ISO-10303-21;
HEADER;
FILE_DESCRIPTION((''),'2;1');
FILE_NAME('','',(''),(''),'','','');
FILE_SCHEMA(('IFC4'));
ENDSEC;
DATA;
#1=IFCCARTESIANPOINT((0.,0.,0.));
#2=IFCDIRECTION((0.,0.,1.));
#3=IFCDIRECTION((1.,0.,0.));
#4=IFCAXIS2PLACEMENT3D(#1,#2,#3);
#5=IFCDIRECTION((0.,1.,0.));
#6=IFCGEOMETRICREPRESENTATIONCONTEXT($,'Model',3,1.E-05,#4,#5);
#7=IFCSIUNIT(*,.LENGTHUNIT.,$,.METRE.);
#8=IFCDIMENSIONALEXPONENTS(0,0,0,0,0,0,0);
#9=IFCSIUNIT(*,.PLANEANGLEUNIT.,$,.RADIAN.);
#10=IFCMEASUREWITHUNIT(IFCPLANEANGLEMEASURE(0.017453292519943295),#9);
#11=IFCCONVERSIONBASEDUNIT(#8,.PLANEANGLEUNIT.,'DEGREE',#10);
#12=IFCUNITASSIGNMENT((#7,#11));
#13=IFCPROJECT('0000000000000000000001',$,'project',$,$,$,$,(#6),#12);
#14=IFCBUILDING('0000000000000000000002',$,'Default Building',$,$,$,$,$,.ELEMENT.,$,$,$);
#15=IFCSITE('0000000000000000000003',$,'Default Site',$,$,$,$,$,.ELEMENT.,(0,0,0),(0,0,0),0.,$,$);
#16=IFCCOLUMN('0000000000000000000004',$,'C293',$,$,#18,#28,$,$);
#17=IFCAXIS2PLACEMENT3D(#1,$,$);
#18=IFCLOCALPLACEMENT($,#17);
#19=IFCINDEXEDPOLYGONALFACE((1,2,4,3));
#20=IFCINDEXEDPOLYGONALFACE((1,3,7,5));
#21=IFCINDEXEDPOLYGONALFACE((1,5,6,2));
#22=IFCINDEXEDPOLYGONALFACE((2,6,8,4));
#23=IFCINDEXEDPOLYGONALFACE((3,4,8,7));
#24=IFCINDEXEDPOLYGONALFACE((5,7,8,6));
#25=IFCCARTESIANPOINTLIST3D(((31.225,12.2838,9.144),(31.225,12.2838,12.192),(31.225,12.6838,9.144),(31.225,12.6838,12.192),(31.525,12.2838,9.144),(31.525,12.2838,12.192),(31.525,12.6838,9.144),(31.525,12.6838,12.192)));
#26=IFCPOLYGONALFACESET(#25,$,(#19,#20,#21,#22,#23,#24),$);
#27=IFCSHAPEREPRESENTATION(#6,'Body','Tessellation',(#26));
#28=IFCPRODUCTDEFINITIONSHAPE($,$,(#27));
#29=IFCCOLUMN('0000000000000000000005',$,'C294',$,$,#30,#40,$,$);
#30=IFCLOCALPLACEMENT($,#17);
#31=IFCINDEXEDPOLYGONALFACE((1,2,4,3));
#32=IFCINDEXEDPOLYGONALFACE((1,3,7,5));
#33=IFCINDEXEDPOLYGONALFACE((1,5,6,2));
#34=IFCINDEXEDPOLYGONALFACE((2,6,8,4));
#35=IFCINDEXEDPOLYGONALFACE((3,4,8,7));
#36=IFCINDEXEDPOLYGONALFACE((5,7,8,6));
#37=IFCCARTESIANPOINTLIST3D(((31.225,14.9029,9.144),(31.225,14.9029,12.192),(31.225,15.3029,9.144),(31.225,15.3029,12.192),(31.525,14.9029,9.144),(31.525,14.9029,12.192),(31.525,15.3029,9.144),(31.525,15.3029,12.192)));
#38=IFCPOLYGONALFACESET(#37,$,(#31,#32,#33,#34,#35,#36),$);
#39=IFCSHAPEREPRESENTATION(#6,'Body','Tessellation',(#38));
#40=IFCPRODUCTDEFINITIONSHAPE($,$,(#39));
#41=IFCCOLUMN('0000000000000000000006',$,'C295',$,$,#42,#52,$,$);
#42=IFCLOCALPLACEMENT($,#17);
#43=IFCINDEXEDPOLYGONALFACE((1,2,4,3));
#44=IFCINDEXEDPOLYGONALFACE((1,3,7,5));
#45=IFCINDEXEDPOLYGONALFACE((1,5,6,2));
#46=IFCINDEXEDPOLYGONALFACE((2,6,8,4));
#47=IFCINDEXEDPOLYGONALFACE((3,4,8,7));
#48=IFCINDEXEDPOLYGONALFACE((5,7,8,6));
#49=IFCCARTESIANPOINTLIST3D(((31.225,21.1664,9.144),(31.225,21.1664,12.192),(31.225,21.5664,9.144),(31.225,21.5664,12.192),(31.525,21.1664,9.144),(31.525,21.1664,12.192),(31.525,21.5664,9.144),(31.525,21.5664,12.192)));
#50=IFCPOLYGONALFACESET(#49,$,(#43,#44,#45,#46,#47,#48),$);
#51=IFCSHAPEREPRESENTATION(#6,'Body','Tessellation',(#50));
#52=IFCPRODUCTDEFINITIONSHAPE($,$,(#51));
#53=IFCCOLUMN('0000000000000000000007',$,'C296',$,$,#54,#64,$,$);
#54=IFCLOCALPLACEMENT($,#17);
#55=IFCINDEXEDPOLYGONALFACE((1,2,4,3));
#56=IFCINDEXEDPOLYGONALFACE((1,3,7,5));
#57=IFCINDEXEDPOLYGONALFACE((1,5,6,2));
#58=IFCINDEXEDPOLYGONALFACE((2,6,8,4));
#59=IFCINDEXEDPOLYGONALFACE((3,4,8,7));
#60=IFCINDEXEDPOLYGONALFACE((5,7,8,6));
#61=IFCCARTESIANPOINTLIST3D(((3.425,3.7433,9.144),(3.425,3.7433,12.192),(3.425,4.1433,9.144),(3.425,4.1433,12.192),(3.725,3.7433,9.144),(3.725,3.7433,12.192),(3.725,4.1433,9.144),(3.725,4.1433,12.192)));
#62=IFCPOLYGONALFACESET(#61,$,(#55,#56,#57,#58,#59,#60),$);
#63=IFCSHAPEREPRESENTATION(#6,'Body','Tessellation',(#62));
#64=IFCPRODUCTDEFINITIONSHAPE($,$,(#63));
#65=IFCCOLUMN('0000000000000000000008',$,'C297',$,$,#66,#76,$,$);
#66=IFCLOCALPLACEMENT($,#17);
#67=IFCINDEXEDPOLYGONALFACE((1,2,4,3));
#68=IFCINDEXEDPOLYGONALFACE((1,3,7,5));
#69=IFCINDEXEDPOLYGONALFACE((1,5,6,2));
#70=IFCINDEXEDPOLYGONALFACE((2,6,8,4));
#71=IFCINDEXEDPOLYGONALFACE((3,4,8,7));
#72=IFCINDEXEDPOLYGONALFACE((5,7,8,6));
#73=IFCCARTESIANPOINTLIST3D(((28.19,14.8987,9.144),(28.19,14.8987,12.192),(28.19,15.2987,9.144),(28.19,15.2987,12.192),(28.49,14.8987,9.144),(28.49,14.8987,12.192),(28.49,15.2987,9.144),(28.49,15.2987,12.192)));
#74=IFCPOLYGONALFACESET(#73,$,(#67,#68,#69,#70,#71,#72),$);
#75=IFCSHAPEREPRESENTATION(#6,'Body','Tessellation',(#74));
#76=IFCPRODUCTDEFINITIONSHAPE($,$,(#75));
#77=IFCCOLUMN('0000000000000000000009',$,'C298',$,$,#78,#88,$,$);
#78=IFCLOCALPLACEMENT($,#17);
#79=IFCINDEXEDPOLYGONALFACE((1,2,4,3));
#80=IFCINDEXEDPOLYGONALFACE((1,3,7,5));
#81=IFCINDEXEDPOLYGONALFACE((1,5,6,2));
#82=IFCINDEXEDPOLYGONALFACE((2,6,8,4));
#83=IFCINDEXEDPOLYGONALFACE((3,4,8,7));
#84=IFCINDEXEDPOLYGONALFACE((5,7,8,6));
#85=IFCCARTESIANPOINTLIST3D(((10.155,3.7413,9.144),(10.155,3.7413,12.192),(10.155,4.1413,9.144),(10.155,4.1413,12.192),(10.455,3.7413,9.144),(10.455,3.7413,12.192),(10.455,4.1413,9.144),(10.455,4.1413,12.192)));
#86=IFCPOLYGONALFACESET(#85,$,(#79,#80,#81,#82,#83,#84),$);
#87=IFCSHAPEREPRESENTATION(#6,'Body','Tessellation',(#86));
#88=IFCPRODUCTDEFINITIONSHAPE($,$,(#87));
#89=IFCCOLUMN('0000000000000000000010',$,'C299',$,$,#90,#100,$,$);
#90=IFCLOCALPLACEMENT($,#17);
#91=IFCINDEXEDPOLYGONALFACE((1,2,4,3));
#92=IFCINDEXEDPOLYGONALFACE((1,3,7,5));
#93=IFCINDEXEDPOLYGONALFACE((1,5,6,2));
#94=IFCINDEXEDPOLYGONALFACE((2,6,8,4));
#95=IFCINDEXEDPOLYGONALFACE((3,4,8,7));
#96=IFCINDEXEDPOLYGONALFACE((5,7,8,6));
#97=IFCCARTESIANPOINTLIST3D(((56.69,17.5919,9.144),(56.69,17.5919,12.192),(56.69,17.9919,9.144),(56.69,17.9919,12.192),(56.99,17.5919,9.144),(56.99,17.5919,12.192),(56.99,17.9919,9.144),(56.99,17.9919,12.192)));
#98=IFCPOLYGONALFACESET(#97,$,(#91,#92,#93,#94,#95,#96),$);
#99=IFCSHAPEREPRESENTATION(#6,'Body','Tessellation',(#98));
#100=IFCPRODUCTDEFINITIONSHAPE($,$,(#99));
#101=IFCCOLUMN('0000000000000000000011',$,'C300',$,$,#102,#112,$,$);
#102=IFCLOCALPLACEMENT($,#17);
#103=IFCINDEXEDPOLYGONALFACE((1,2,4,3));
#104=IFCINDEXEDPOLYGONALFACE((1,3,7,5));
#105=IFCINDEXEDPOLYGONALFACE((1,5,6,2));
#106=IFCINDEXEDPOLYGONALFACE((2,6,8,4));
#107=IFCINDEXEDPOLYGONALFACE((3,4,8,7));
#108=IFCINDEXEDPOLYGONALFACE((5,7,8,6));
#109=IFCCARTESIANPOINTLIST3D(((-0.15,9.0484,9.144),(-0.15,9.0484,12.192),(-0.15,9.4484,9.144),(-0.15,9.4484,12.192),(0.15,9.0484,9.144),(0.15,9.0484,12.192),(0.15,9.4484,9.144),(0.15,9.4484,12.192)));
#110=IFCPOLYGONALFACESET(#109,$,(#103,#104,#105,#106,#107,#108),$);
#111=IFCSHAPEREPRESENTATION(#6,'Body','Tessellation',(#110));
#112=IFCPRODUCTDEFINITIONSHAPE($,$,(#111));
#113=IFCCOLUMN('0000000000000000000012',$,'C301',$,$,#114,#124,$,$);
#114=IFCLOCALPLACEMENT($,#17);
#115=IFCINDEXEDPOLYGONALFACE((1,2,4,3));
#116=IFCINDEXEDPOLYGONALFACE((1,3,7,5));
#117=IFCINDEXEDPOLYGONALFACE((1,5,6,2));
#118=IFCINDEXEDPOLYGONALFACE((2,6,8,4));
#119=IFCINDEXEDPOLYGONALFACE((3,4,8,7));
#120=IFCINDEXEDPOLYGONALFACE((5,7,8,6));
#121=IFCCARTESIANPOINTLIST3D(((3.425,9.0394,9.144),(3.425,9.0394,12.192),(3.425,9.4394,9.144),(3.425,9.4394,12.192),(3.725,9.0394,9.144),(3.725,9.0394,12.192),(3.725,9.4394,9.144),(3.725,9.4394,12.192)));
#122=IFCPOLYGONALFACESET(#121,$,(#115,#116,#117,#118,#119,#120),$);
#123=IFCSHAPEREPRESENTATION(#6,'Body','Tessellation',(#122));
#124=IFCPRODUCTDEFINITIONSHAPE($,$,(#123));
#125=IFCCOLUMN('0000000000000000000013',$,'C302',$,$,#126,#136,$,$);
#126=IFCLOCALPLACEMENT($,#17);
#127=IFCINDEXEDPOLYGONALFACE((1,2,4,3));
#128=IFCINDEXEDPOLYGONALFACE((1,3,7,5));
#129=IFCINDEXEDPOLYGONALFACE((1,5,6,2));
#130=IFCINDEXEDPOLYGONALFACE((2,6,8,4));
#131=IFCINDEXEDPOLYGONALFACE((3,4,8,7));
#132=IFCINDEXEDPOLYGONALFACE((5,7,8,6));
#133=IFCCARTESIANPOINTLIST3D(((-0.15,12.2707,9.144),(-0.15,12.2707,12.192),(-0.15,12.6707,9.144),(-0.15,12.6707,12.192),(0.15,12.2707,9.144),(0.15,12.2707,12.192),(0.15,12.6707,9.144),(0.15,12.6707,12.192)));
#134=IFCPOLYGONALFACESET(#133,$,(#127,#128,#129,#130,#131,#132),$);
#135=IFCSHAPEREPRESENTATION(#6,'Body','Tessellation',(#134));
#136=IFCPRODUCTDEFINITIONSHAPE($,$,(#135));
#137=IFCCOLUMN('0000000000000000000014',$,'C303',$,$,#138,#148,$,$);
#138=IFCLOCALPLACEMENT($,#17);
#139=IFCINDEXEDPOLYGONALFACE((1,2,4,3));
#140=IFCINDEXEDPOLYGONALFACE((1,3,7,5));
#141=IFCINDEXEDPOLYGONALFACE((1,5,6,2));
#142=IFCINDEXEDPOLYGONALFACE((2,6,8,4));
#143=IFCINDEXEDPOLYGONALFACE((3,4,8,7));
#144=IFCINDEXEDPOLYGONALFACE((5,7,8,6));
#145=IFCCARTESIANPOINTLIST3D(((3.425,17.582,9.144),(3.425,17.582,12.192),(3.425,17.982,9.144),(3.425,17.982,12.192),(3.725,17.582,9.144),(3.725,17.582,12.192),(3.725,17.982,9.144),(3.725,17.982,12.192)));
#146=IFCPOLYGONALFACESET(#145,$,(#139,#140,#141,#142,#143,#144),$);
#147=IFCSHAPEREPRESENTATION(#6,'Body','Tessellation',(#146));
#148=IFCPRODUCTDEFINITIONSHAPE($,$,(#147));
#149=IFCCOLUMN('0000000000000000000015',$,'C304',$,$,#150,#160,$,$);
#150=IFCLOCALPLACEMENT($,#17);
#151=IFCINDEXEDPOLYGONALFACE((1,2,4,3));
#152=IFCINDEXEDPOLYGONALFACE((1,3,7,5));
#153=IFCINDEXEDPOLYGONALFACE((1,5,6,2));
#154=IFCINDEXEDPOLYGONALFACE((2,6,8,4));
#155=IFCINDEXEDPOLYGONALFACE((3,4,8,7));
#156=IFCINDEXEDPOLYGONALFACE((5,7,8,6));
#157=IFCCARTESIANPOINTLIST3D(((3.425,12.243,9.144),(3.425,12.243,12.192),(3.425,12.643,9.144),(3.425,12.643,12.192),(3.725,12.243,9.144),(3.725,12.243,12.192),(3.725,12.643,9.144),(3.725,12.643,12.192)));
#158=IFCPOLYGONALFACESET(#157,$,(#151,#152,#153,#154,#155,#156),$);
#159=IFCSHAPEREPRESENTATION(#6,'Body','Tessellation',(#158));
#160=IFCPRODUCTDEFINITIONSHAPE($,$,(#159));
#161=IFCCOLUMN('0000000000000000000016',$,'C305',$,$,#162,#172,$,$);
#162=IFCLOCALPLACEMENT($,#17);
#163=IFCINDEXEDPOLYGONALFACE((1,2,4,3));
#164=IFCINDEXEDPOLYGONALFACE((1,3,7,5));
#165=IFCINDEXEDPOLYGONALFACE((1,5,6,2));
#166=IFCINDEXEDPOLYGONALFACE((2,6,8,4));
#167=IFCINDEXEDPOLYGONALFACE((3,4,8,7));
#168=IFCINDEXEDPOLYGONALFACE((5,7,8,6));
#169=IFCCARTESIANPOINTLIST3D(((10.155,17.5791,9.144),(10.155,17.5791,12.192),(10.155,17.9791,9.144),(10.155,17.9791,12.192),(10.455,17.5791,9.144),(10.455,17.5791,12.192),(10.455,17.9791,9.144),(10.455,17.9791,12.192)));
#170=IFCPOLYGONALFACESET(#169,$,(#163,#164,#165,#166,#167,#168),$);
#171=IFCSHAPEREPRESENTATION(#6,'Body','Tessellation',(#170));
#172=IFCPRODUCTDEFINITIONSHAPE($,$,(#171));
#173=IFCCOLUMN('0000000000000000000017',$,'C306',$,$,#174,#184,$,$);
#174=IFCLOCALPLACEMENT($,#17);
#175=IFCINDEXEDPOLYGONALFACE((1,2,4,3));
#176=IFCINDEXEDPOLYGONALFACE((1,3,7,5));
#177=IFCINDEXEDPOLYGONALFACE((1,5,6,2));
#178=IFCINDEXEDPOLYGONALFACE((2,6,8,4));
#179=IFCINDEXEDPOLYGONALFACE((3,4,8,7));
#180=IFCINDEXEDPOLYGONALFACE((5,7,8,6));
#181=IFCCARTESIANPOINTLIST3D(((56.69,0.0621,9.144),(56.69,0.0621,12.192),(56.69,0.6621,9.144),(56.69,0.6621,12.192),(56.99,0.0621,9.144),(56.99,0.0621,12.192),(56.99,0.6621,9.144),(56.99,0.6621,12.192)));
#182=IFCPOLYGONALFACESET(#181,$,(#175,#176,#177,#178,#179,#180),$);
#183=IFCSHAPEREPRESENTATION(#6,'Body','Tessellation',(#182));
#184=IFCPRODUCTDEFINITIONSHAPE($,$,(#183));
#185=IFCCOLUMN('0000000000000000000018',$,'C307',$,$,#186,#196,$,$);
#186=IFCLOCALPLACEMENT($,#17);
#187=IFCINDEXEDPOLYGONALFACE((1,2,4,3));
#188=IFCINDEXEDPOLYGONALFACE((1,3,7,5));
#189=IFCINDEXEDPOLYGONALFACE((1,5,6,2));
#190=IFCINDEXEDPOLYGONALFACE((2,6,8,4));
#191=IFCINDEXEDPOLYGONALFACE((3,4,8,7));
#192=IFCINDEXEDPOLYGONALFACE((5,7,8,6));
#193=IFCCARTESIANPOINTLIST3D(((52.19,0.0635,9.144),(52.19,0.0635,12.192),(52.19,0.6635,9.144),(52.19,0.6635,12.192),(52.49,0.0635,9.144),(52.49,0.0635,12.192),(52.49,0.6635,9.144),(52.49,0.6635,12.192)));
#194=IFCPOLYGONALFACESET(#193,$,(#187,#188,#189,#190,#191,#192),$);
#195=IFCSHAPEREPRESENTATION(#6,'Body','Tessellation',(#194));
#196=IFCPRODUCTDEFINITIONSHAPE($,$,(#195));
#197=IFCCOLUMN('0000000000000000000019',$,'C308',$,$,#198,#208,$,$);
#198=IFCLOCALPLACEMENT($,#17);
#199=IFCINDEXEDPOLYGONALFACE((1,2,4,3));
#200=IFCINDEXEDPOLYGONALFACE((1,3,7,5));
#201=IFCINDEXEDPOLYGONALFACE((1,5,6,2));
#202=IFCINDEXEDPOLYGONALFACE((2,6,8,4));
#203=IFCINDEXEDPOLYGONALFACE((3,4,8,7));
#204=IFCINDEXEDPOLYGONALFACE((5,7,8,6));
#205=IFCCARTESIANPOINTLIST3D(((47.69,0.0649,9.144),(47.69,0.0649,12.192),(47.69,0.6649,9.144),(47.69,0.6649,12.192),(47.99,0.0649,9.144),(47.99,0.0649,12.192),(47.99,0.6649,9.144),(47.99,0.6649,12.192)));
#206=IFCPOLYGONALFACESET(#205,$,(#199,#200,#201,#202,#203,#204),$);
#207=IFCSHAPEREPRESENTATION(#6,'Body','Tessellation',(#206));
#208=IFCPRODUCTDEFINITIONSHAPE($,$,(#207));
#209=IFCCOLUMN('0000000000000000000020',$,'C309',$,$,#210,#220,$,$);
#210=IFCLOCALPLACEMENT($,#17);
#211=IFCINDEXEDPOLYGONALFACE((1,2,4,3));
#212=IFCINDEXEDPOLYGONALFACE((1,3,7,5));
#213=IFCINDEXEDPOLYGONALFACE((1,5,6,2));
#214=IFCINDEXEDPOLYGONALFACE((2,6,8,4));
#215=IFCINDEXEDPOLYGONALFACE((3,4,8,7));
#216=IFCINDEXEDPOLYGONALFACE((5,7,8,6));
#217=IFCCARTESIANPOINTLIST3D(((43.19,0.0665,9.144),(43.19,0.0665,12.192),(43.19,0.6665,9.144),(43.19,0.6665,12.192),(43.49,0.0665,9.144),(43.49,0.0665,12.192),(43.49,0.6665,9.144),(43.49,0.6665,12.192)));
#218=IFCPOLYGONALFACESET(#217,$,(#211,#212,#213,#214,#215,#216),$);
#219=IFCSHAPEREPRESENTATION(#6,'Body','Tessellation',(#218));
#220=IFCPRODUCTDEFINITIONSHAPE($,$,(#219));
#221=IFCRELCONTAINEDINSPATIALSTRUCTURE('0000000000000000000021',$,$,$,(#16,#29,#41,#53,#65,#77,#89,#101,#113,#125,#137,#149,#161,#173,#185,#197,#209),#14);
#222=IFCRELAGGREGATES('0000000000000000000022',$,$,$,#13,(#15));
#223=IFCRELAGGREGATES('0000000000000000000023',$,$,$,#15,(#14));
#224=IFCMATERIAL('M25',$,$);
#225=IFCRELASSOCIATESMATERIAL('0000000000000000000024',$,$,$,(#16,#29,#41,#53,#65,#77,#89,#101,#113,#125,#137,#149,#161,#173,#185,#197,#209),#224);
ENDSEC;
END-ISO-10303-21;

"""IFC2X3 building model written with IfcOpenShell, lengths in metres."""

from ifc_helpers import new_model, entity, si_unit, converted_unit, direction, frame, frame_2d, origin_with_axes, place, context, project, spatial, rectangle, extrude, material, element, save


model = new_model("IFC2X3")

# Units and contexts
model_context = context("Model", 3, precision=1e-05, world=origin_with_axes(), true_north=direction((0.0, 1.0, 0.0)))
ifc_project = project(units=[si_unit("LENGTHUNIT", "METRE"), converted_unit("PLANEANGLEUNIT", "DEGREE", entity("IfcPlaneAngleMeasure", 0.017453292519943295), si_unit("PLANEANGLEUNIT", "RADIAN"), dimensions=[0, 0, 0, 0, 0, 0, 0])], contexts=[model_context])

# Site, building
site = spatial("IfcSite", under=ifc_project, Name="Default Site", CompositionType="ELEMENT", RefLatitude=(0, 0, 0), RefLongitude=(0, 0, 0), RefElevation=0.0)
building = spatial("IfcBuilding", under=site, Name="Default Building", CompositionType="ELEMENT")

# Columns
ifc_material = material(Name="M25")
placement = place(None, origin_with_axes())
element("IfcColumn", 1, at=placement, inside=building, material=ifc_material, Name="C293", context=model_context, shape_type="SweptSolid", body=[
    extrude(rectangle(XDim=0.3, YDim=0.4, at=frame_2d((0.0, 0.0), x_axis=(1.0, 0.0, 0.0))), frame((31.375, 12.4838, 9.144), z_axis=(0.0, 0.0, 1.0), x_axis=(1.0, 0.0, 0.0)), (0.0, 0.0, 1.0), 3.048),
])
element("IfcColumn", 2, at=placement, inside=building, material=ifc_material, Name="C294", context=model_context, shape_type="SweptSolid", body=[
    extrude(rectangle(XDim=0.3, YDim=0.4, at=frame_2d((0.0, 0.0), x_axis=(1.0, 0.0, 0.0))), frame((31.375, 15.1029, 9.144), z_axis=(0.0, 0.0, 1.0), x_axis=(1.0, 0.0, 0.0)), (0.0, 0.0, 1.0), 3.048),
])
element("IfcColumn", 3, at=placement, inside=building, material=ifc_material, Name="C295", context=model_context, shape_type="SweptSolid", body=[
    extrude(rectangle(XDim=0.3, YDim=0.4, at=frame_2d((0.0, 0.0), x_axis=(1.0, 0.0, 0.0))), frame((31.375, 21.3664, 9.144), z_axis=(0.0, 0.0, 1.0), x_axis=(1.0, 0.0, 0.0)), (0.0, 0.0, 1.0), 3.048),
])
element("IfcColumn", 4, at=placement, inside=building, material=ifc_material, Name="C296", context=model_context, shape_type="SweptSolid", body=[
    extrude(rectangle(XDim=0.3, YDim=0.4, at=frame_2d((0.0, 0.0), x_axis=(1.0, 0.0, 0.0))), frame((3.575, 3.9433, 9.144), z_axis=(0.0, 0.0, 1.0), x_axis=(1.0, 0.0, 0.0)), (0.0, 0.0, 1.0), 3.048),
])
element("IfcColumn", 5, at=placement, inside=building, material=ifc_material, Name="C297", context=model_context, shape_type="SweptSolid", body=[
    extrude(rectangle(XDim=0.3, YDim=0.4, at=frame_2d((0.0, 0.0), x_axis=(1.0, 0.0, 0.0))), frame((28.34, 15.0987, 9.144), z_axis=(0.0, 0.0, 1.0), x_axis=(1.0, 0.0, 0.0)), (0.0, 0.0, 1.0), 3.048),
])
element("IfcColumn", 6, at=placement, inside=building, material=ifc_material, Name="C298", context=model_context, shape_type="SweptSolid", body=[
    extrude(rectangle(XDim=0.3, YDim=0.4, at=frame_2d((0.0, 0.0), x_axis=(1.0, 0.0, 0.0))), frame((10.305, 3.9413, 9.144), z_axis=(0.0, 0.0, 1.0), x_axis=(1.0, 0.0, 0.0)), (0.0, 0.0, 1.0), 3.048),
])
element("IfcColumn", 7, at=placement, inside=building, material=ifc_material, Name="C299", context=model_context, shape_type="SweptSolid", body=[
    extrude(rectangle(XDim=0.3, YDim=0.4, at=frame_2d((0.0, 0.0), x_axis=(1.0, 0.0, 0.0))), frame((56.84, 17.7919, 9.144), z_axis=(0.0, 0.0, 1.0), x_axis=(1.0, 0.0, 0.0)), (0.0, 0.0, 1.0), 3.048),
])
element("IfcColumn", 8, at=placement, inside=building, material=ifc_material, Name="C300", context=model_context, shape_type="SweptSolid", body=[
    extrude(rectangle(XDim=0.3, YDim=0.4, at=frame_2d((0.0, 0.0), x_axis=(1.0, 0.0, 0.0))), frame((0.0, 9.2484, 9.144), z_axis=(0.0, 0.0, 1.0), x_axis=(1.0, 0.0, 0.0)), (0.0, 0.0, 1.0), 3.048),
])
element("IfcColumn", 9, at=placement, inside=building, material=ifc_material, Name="C301", context=model_context, shape_type="SweptSolid", body=[
    extrude(rectangle(XDim=0.3, YDim=0.4, at=frame_2d((0.0, 0.0), x_axis=(1.0, 0.0, 0.0))), frame((3.575, 9.2394, 9.144), z_axis=(0.0, 0.0, 1.0), x_axis=(1.0, 0.0, 0.0)), (0.0, 0.0, 1.0), 3.048),
])
element("IfcColumn", 10, at=placement, inside=building, material=ifc_material, Name="C302", context=model_context, shape_type="SweptSolid", body=[
    extrude(rectangle(XDim=0.3, YDim=0.4, at=frame_2d((0.0, 0.0), x_axis=(1.0, 0.0, 0.0))), frame((0.0, 12.4707, 9.144), z_axis=(0.0, 0.0, 1.0), x_axis=(1.0, 0.0, 0.0)), (0.0, 0.0, 1.0), 3.048),
])
element("IfcColumn", 11, at=placement, inside=building, material=ifc_material, Name="C303", context=model_context, shape_type="SweptSolid", body=[
    extrude(rectangle(XDim=0.3, YDim=0.4, at=frame_2d((0.0, 0.0), x_axis=(1.0, 0.0, 0.0))), frame((3.575, 17.782, 9.144), z_axis=(0.0, 0.0, 1.0), x_axis=(1.0, 0.0, 0.0)), (0.0, 0.0, 1.0), 3.048),
])
element("IfcColumn", 12, at=placement, inside=building, material=ifc_material, Name="C304", context=model_context, shape_type="SweptSolid", body=[
    extrude(rectangle(XDim=0.3, YDim=0.4, at=frame_2d((0.0, 0.0), x_axis=(1.0, 0.0, 0.0))), frame((3.575, 12.443, 9.144), z_axis=(0.0, 0.0, 1.0), x_axis=(1.0, 0.0, 0.0)), (0.0, 0.0, 1.0), 3.048),
])
element("IfcColumn", 13, at=placement, inside=building, material=ifc_material, Name="C305", context=model_context, shape_type="SweptSolid", body=[
    extrude(rectangle(XDim=0.3, YDim=0.4, at=frame_2d((0.0, 0.0), x_axis=(1.0, 0.0, 0.0))), frame((10.305, 17.7791, 9.144), z_axis=(0.0, 0.0, 1.0), x_axis=(1.0, 0.0, 0.0)), (0.0, 0.0, 1.0), 3.048),
])
element("IfcColumn", 14, at=placement, inside=building, material=ifc_material, Name="C306", context=model_context, shape_type="SweptSolid", body=[
    extrude(rectangle(XDim=0.3, YDim=0.6, at=frame_2d((0.0, 0.0), x_axis=(1.0, 0.0, 0.0))), frame((56.84, 0.3621, 9.144), z_axis=(0.0, 0.0, 1.0), x_axis=(1.0, 0.0, 0.0)), (0.0, 0.0, 1.0), 3.048),
])
element("IfcColumn", 15, at=placement, inside=building, material=ifc_material, Name="C307", context=model_context, shape_type="SweptSolid", body=[
    extrude(rectangle(XDim=0.3, YDim=0.6, at=frame_2d((0.0, 0.0), x_axis=(1.0, 0.0, 0.0))), frame((52.34, 0.3635, 9.144), z_axis=(0.0, 0.0, 1.0), x_axis=(1.0, 0.0, 0.0)), (0.0, 0.0, 1.0), 3.048),
])
element("IfcColumn", 16, at=placement, inside=building, material=ifc_material, Name="C308", context=model_context, shape_type="SweptSolid", body=[
    extrude(rectangle(XDim=0.3, YDim=0.6, at=frame_2d((0.0, 0.0), x_axis=(1.0, 0.0, 0.0))), frame((47.84, 0.3649, 9.144), z_axis=(0.0, 0.0, 1.0), x_axis=(1.0, 0.0, 0.0)), (0.0, 0.0, 1.0), 3.048),
])
element("IfcColumn", 17, at=placement, inside=building, material=ifc_material, Name="C309", context=model_context, shape_type="SweptSolid", body=[
    extrude(rectangle(XDim=0.3, YDim=0.6, at=frame_2d((0.0, 0.0), x_axis=(1.0, 0.0, 0.0))), frame((43.34, 0.3665, 9.144), z_axis=(0.0, 0.0, 1.0), x_axis=(1.0, 0.0, 0.0)), (0.0, 0.0, 1.0), 3.048),
])

save(model, "model.ifc")
